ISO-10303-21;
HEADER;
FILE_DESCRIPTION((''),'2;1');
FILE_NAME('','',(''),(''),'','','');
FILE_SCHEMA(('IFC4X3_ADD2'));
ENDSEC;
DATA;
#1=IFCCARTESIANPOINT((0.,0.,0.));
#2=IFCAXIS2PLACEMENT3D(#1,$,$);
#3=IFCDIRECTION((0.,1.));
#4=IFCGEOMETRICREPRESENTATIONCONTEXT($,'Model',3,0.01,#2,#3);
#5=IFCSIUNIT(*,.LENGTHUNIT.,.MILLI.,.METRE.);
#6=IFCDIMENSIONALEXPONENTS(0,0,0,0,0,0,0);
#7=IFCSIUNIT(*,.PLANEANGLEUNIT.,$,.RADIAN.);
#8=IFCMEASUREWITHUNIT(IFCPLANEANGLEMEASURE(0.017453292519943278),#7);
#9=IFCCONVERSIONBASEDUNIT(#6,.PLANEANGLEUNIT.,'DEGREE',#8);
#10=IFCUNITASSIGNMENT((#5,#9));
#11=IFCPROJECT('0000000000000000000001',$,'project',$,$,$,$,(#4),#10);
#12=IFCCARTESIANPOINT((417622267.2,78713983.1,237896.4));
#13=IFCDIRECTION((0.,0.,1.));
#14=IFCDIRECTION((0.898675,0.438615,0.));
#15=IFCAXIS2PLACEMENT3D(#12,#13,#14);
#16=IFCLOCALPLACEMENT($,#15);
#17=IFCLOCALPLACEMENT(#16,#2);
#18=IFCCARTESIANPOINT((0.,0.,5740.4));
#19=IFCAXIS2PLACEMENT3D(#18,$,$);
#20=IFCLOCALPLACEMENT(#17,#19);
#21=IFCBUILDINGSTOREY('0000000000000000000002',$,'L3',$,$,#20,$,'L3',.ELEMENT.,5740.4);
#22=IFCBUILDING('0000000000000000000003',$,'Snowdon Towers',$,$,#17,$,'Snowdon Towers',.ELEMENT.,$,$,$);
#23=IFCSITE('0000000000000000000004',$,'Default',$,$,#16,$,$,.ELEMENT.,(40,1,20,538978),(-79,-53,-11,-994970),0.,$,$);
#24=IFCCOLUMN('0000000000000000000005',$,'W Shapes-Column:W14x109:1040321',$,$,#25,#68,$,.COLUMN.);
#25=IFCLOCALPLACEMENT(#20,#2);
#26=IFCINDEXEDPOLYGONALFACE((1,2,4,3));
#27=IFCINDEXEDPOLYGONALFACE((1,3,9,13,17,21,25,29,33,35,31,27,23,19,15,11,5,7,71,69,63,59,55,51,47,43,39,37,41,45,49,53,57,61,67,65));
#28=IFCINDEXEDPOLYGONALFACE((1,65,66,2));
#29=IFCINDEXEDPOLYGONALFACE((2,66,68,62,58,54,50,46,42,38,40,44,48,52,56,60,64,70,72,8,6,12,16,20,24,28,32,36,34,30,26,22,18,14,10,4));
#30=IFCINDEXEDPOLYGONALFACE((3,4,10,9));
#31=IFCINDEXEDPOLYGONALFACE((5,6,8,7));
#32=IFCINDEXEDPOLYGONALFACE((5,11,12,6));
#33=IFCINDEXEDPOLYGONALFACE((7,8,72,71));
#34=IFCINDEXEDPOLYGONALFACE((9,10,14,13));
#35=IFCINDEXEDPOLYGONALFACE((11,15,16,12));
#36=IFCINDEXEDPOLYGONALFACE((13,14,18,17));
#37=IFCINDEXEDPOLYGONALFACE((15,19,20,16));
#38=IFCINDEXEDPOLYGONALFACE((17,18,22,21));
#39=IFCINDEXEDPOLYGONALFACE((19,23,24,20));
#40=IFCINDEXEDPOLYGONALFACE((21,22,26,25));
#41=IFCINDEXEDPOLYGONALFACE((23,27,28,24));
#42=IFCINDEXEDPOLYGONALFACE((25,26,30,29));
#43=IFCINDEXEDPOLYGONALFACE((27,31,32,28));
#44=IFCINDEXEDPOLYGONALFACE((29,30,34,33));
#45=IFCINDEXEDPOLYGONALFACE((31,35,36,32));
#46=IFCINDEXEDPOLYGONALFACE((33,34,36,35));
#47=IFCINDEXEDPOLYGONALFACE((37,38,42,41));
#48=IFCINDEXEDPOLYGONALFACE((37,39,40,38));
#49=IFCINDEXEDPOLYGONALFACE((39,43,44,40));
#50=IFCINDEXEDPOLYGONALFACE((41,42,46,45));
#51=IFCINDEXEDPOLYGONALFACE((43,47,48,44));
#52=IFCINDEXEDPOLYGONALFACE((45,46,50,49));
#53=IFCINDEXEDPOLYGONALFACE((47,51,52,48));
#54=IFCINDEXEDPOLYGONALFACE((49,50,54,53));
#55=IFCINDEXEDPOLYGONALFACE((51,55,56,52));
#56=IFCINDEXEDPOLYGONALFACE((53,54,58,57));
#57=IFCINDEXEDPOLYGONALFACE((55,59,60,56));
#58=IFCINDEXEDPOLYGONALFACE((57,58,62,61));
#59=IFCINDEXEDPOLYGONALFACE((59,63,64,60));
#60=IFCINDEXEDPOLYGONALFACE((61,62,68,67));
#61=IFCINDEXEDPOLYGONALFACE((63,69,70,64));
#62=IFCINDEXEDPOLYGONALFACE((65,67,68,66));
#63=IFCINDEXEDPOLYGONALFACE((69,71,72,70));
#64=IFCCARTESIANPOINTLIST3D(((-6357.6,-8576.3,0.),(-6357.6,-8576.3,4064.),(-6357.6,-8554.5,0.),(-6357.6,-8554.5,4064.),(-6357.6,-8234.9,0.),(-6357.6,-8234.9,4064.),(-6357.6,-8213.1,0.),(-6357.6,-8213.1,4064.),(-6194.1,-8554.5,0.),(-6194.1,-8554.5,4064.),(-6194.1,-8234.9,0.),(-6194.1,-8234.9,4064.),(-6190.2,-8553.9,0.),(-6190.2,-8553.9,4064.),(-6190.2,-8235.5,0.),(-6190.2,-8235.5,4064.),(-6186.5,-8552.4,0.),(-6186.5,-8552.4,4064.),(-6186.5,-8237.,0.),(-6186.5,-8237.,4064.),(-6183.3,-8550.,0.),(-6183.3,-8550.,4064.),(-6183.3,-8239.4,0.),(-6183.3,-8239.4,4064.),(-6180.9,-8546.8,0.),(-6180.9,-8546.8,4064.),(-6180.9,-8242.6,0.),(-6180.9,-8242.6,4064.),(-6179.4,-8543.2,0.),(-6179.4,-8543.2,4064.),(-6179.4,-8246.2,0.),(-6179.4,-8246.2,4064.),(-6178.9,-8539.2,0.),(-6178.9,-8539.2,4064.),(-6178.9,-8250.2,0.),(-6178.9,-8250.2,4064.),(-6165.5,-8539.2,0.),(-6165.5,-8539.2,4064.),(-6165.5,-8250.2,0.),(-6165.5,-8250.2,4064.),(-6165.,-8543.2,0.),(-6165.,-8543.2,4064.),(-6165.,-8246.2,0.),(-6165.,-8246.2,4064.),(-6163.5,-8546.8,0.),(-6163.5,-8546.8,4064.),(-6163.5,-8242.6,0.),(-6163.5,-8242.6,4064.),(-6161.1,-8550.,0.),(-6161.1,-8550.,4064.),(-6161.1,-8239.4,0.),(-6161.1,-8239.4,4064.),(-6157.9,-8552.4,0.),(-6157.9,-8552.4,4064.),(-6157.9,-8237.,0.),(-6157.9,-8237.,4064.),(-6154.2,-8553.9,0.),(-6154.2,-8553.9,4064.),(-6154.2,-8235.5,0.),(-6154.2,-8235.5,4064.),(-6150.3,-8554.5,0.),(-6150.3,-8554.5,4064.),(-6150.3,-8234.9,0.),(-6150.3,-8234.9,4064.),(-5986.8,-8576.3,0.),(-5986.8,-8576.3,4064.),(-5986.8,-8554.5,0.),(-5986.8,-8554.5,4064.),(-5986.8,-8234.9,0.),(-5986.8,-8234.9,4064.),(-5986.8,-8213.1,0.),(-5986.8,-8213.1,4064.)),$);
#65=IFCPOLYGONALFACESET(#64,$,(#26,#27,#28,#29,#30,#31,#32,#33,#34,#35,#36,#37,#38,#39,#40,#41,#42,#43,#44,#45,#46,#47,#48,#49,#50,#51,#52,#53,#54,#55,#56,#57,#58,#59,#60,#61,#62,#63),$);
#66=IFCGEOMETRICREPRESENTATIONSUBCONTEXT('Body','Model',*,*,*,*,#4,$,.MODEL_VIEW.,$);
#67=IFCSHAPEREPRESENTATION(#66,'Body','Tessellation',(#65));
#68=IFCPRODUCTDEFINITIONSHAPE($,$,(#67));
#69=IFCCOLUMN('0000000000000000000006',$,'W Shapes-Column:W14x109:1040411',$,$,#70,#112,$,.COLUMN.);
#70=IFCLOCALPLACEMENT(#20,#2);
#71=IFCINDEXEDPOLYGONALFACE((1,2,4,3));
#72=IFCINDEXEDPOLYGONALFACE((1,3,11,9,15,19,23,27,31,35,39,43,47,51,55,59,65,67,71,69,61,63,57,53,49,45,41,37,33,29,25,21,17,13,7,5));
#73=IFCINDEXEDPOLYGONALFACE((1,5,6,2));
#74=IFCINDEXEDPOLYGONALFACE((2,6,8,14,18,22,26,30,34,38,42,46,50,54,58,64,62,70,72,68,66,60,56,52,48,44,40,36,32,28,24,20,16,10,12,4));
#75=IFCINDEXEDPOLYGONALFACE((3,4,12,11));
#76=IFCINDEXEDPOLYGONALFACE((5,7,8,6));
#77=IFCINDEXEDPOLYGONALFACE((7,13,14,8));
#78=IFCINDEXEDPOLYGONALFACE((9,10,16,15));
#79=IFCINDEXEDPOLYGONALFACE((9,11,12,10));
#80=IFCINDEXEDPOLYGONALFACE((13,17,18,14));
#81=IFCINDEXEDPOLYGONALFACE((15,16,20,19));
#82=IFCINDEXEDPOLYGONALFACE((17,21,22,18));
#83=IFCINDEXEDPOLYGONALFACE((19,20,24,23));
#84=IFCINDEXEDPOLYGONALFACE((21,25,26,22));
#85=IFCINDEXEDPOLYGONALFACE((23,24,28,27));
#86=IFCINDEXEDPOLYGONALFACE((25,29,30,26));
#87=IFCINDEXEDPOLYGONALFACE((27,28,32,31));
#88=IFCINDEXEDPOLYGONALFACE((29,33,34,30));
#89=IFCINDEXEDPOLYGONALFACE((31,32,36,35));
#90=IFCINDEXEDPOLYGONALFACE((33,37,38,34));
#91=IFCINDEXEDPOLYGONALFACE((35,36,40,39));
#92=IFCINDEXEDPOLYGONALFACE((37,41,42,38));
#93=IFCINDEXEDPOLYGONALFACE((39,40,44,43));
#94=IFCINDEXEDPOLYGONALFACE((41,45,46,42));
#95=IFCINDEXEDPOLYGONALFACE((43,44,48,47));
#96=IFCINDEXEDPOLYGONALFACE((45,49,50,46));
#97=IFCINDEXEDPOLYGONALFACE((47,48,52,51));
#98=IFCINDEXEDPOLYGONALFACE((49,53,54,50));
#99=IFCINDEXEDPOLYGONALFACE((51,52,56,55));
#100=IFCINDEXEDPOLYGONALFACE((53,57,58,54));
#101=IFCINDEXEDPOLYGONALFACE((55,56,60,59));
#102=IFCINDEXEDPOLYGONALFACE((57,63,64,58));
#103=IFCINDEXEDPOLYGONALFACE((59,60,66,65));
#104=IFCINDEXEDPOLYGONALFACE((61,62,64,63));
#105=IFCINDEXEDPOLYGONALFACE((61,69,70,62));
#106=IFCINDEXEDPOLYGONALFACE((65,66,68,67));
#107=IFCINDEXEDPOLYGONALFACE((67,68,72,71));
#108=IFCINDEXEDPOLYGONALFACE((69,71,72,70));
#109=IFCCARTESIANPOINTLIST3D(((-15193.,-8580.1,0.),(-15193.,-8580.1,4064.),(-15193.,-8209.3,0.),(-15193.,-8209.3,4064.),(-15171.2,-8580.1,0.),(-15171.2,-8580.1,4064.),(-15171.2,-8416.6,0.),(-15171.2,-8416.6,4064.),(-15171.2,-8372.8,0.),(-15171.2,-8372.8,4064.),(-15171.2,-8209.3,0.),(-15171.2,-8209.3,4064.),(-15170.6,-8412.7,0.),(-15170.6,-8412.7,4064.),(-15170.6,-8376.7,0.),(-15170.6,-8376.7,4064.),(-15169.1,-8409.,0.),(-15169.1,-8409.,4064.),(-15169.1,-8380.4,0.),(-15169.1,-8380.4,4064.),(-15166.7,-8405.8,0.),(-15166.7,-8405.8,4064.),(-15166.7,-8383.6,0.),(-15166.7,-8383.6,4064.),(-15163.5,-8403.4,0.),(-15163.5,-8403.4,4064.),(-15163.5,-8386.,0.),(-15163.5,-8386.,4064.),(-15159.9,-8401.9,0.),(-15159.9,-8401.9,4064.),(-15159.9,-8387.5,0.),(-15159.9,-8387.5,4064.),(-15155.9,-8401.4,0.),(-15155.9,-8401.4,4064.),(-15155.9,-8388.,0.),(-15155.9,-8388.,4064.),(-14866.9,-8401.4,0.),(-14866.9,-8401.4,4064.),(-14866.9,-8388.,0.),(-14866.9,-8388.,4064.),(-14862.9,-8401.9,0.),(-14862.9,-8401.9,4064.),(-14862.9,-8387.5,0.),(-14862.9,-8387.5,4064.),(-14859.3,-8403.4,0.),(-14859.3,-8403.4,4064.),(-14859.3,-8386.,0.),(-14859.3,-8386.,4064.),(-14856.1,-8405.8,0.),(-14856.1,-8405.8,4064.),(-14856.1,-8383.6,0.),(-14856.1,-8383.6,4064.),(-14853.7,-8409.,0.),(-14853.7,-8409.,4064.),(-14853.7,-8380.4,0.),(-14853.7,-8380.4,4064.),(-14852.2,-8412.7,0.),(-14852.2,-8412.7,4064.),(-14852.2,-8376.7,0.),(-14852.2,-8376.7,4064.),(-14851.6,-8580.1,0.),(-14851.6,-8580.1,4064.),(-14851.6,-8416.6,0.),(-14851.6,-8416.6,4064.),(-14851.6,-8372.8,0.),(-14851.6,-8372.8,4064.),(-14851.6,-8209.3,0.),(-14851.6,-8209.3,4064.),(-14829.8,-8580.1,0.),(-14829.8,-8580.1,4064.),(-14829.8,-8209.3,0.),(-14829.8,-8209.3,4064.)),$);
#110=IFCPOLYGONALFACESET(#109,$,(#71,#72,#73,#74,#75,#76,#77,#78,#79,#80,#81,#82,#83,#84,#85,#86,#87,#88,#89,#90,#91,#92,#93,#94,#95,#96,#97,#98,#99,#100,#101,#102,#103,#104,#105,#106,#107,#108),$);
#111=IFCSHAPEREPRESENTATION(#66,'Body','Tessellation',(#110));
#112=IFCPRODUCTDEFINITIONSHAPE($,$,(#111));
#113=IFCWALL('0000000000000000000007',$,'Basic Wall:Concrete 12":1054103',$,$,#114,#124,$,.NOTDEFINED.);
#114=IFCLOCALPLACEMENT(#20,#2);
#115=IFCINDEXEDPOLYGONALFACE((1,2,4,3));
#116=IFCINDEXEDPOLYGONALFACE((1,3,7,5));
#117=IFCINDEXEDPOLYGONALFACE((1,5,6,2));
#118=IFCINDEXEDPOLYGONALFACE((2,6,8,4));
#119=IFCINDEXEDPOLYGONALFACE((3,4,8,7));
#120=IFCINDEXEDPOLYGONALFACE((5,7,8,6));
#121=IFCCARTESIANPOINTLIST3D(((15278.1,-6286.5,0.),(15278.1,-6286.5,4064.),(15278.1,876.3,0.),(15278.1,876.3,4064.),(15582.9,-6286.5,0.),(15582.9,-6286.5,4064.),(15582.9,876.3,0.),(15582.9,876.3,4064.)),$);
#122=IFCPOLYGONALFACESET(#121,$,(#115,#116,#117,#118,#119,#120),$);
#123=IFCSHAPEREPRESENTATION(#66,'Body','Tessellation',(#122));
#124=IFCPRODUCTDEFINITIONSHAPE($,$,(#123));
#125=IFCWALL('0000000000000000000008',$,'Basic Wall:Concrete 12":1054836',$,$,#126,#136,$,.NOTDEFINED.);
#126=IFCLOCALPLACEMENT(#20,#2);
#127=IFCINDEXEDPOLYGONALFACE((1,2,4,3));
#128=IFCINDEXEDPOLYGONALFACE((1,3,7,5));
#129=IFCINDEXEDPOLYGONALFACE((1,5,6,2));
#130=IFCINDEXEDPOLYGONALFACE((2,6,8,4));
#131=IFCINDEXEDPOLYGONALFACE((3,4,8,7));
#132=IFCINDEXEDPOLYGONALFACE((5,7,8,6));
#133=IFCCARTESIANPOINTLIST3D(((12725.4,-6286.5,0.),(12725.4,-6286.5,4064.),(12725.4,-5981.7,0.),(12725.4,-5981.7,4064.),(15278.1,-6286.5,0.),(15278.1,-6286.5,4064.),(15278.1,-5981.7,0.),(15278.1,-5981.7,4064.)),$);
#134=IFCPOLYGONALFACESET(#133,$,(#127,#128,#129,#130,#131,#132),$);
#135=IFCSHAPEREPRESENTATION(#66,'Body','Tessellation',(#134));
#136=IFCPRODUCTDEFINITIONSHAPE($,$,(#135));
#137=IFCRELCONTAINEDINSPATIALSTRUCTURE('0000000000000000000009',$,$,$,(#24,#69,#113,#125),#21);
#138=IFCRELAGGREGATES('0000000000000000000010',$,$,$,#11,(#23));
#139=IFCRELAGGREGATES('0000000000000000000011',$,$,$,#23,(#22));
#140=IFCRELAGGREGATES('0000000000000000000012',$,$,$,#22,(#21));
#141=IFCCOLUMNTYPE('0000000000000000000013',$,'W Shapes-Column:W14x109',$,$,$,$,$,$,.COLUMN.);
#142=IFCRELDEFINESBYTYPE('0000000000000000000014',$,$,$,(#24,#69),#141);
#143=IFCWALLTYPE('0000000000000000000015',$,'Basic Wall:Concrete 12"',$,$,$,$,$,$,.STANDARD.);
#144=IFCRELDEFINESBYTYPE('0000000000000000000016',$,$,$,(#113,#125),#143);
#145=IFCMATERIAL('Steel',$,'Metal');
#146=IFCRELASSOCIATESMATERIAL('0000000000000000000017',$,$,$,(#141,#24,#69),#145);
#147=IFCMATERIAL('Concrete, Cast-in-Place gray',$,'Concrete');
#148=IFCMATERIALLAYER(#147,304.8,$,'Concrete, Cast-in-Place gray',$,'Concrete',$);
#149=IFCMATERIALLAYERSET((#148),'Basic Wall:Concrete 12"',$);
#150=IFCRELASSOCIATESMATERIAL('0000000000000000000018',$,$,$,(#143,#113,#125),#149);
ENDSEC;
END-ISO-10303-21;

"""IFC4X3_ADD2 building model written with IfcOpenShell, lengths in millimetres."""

from ifc_helpers import new_model, entity, si_unit, converted_unit, direction, frame, frame_2d, origin, place, context, subcontext, project, spatial, rectangle, i_section, extrude, source, transform, mapped, material, layer, layer_set, material_profile, profile_set, profile_usage, type_object, type_shapes, element, save


model = new_model("IFC4X3_ADD2")

# Units and contexts
model_context = context("Model", 3, precision=0.01, world=origin(), true_north=direction((0.0, 1.0)))
body_context = subcontext(model_context, "Body", "Model", "MODEL_VIEW")
ifc_project = project(units=[si_unit("LENGTHUNIT", "METRE", prefix="MILLI"), converted_unit("PLANEANGLEUNIT", "DEGREE", entity("IfcPlaneAngleMeasure", 0.017453292519943278), si_unit("PLANEANGLEUNIT", "RADIAN"), dimensions=[0, 0, 0, 0, 0, 0, 0])], contexts=[model_context])

# Site, building, storey
site_placement = place(None, frame((417622267.2, 78713983.1, 237896.4), z_axis=(0.0, 0.0, 1.0), x_axis=(0.898675, 0.438615, 0.0)))
site = spatial("IfcSite", under=ifc_project, at=site_placement, Name="Default", CompositionType="ELEMENT", RefLatitude=(40, 1, 20, 538978), RefLongitude=(-79, -53, -11, -994970), RefElevation=0.0)
building_placement = place(site_placement, origin())
building = spatial("IfcBuilding", under=site, at=building_placement, Name="Snowdon Towers", LongName="Snowdon Towers", CompositionType="ELEMENT")
storey_placement = place(building_placement, frame((0.0, 0.0, 5740.4)))
storey = spatial("IfcBuildingStorey", under=building, at=storey_placement, Name="L3", LongName="L3", CompositionType="ELEMENT", Elevation=5740.4)

# Columns
ifc_material_1 = material(Name="Steel", Category="Metal")
ifc_material_profile_1 = material_profile(ifc_material_1, i_section(OverallWidth=370.8, OverallDepth=363.2, WebThickness=13.3, FlangeThickness=21.8, FilletRadius=15.2, at=frame_2d((0.0, 0.0), x_axis=(1.0, 0.0))), Name="W14x109")
ifc_profile_set_1 = profile_set([ifc_material_profile_1], Name="W14x109")
ifc_profile_usage_1 = profile_usage(ifc_profile_set_1)
column_type_1 = type_object("IfcColumnType", Name="W Shapes-Column:W14x109", PredefinedType="COLUMN", material=ifc_profile_set_1)
shared_shape_1 = source(origin(), body_context, "Body", "SweptSolid", [
    extrude(i_section(OverallWidth=370.8, OverallDepth=363.2, WebThickness=13.3, FlangeThickness=21.8, FilletRadius=15.2, at=frame_2d((0.0, 0.0), x_axis=(1.0, 0.0))), frame((0.0, 0.0, 5740.4), z_axis=(0.0, 0.0, 1.0), x_axis=(-1.0, 0.0, 0.0)), (0.0, 0.0, 1.0), 4064.0),
])
type_shapes(column_type_1, [shared_shape_1])
for number, where, z_axis, x_axis, name in (
    (1, (-6172.2, -8394.7, -5740.4), (0.0, 0.0, 1.0), (-1.0, 0.0, 0.0), "W Shapes-Column:W14x109:1040321"),
    (2, (-15011.4, -8394.7, -5740.4), (0.0, 0.0, 1.0), (0.0, 1.0, 0.0), "W Shapes-Column:W14x109:1040411"),
):
    element("IfcColumn", number, at=place(storey_placement, frame(where, z_axis=z_axis, x_axis=x_axis)), inside=storey, type_object=column_type_1, material=ifc_profile_usage_1, Name=name, PredefinedType="COLUMN", context=body_context, shape_type="MappedRepresentation", body=[
        mapped(shared_shape_1, transform((0.0, 0.0, 0.0), scale=1.0)),
    ])

# Shared definitions
ifc_material_2 = material(Name="Concrete, Cast-in-Place gray", Category="Concrete")

# Walls
ifc_layer_1 = layer(ifc_material_2, 304.8, Name="Concrete, Cast-in-Place gray", Category="Concrete")
ifc_layer_set_1 = layer_set([ifc_layer_1], Name="Basic Wall:Concrete 12\"")
wall_type = type_object("IfcWallType", Name="Basic Wall:Concrete 12\"", PredefinedType="STANDARD", material=ifc_layer_set_1)
wall_1_placement = place(storey_placement, frame((15430.5, -6286.5, 0.0), z_axis=(0.0, 0.0, 1.0), x_axis=(0.0, 1.0, 0.0)))
element("IfcWall", 3, at=wall_1_placement, inside=storey, type_object=wall_type, material=ifc_layer_set_1, Name="Basic Wall:Concrete 12\":1054103", PredefinedType="NOTDEFINED", context=body_context, shape_type="SweptSolid", body=[
    extrude(rectangle(XDim=7162.8, YDim=304.8, at=frame_2d((3581.4, 0.0), x_axis=(-1.0, 0.0))), origin(), (0.0, 0.0, 1.0), 4064.0),
])
wall_2_placement = place(storey_placement, frame((15278.1, -6134.1, 0.0), z_axis=(0.0, 0.0, 1.0), x_axis=(-1.0, 0.0, 0.0)))
element("IfcWall", 4, at=wall_2_placement, inside=storey, type_object=wall_type, material=ifc_layer_set_1, Name="Basic Wall:Concrete 12\":1054836", PredefinedType="NOTDEFINED", context=body_context, shape_type="SweptSolid", body=[
    extrude(rectangle(XDim=2552.7, YDim=304.8, at=frame_2d((1276.3, 0.0), x_axis=(-1.0, 0.0))), origin(), (0.0, 0.0, 1.0), 4064.0),
])

save(model, "model.ifc")
